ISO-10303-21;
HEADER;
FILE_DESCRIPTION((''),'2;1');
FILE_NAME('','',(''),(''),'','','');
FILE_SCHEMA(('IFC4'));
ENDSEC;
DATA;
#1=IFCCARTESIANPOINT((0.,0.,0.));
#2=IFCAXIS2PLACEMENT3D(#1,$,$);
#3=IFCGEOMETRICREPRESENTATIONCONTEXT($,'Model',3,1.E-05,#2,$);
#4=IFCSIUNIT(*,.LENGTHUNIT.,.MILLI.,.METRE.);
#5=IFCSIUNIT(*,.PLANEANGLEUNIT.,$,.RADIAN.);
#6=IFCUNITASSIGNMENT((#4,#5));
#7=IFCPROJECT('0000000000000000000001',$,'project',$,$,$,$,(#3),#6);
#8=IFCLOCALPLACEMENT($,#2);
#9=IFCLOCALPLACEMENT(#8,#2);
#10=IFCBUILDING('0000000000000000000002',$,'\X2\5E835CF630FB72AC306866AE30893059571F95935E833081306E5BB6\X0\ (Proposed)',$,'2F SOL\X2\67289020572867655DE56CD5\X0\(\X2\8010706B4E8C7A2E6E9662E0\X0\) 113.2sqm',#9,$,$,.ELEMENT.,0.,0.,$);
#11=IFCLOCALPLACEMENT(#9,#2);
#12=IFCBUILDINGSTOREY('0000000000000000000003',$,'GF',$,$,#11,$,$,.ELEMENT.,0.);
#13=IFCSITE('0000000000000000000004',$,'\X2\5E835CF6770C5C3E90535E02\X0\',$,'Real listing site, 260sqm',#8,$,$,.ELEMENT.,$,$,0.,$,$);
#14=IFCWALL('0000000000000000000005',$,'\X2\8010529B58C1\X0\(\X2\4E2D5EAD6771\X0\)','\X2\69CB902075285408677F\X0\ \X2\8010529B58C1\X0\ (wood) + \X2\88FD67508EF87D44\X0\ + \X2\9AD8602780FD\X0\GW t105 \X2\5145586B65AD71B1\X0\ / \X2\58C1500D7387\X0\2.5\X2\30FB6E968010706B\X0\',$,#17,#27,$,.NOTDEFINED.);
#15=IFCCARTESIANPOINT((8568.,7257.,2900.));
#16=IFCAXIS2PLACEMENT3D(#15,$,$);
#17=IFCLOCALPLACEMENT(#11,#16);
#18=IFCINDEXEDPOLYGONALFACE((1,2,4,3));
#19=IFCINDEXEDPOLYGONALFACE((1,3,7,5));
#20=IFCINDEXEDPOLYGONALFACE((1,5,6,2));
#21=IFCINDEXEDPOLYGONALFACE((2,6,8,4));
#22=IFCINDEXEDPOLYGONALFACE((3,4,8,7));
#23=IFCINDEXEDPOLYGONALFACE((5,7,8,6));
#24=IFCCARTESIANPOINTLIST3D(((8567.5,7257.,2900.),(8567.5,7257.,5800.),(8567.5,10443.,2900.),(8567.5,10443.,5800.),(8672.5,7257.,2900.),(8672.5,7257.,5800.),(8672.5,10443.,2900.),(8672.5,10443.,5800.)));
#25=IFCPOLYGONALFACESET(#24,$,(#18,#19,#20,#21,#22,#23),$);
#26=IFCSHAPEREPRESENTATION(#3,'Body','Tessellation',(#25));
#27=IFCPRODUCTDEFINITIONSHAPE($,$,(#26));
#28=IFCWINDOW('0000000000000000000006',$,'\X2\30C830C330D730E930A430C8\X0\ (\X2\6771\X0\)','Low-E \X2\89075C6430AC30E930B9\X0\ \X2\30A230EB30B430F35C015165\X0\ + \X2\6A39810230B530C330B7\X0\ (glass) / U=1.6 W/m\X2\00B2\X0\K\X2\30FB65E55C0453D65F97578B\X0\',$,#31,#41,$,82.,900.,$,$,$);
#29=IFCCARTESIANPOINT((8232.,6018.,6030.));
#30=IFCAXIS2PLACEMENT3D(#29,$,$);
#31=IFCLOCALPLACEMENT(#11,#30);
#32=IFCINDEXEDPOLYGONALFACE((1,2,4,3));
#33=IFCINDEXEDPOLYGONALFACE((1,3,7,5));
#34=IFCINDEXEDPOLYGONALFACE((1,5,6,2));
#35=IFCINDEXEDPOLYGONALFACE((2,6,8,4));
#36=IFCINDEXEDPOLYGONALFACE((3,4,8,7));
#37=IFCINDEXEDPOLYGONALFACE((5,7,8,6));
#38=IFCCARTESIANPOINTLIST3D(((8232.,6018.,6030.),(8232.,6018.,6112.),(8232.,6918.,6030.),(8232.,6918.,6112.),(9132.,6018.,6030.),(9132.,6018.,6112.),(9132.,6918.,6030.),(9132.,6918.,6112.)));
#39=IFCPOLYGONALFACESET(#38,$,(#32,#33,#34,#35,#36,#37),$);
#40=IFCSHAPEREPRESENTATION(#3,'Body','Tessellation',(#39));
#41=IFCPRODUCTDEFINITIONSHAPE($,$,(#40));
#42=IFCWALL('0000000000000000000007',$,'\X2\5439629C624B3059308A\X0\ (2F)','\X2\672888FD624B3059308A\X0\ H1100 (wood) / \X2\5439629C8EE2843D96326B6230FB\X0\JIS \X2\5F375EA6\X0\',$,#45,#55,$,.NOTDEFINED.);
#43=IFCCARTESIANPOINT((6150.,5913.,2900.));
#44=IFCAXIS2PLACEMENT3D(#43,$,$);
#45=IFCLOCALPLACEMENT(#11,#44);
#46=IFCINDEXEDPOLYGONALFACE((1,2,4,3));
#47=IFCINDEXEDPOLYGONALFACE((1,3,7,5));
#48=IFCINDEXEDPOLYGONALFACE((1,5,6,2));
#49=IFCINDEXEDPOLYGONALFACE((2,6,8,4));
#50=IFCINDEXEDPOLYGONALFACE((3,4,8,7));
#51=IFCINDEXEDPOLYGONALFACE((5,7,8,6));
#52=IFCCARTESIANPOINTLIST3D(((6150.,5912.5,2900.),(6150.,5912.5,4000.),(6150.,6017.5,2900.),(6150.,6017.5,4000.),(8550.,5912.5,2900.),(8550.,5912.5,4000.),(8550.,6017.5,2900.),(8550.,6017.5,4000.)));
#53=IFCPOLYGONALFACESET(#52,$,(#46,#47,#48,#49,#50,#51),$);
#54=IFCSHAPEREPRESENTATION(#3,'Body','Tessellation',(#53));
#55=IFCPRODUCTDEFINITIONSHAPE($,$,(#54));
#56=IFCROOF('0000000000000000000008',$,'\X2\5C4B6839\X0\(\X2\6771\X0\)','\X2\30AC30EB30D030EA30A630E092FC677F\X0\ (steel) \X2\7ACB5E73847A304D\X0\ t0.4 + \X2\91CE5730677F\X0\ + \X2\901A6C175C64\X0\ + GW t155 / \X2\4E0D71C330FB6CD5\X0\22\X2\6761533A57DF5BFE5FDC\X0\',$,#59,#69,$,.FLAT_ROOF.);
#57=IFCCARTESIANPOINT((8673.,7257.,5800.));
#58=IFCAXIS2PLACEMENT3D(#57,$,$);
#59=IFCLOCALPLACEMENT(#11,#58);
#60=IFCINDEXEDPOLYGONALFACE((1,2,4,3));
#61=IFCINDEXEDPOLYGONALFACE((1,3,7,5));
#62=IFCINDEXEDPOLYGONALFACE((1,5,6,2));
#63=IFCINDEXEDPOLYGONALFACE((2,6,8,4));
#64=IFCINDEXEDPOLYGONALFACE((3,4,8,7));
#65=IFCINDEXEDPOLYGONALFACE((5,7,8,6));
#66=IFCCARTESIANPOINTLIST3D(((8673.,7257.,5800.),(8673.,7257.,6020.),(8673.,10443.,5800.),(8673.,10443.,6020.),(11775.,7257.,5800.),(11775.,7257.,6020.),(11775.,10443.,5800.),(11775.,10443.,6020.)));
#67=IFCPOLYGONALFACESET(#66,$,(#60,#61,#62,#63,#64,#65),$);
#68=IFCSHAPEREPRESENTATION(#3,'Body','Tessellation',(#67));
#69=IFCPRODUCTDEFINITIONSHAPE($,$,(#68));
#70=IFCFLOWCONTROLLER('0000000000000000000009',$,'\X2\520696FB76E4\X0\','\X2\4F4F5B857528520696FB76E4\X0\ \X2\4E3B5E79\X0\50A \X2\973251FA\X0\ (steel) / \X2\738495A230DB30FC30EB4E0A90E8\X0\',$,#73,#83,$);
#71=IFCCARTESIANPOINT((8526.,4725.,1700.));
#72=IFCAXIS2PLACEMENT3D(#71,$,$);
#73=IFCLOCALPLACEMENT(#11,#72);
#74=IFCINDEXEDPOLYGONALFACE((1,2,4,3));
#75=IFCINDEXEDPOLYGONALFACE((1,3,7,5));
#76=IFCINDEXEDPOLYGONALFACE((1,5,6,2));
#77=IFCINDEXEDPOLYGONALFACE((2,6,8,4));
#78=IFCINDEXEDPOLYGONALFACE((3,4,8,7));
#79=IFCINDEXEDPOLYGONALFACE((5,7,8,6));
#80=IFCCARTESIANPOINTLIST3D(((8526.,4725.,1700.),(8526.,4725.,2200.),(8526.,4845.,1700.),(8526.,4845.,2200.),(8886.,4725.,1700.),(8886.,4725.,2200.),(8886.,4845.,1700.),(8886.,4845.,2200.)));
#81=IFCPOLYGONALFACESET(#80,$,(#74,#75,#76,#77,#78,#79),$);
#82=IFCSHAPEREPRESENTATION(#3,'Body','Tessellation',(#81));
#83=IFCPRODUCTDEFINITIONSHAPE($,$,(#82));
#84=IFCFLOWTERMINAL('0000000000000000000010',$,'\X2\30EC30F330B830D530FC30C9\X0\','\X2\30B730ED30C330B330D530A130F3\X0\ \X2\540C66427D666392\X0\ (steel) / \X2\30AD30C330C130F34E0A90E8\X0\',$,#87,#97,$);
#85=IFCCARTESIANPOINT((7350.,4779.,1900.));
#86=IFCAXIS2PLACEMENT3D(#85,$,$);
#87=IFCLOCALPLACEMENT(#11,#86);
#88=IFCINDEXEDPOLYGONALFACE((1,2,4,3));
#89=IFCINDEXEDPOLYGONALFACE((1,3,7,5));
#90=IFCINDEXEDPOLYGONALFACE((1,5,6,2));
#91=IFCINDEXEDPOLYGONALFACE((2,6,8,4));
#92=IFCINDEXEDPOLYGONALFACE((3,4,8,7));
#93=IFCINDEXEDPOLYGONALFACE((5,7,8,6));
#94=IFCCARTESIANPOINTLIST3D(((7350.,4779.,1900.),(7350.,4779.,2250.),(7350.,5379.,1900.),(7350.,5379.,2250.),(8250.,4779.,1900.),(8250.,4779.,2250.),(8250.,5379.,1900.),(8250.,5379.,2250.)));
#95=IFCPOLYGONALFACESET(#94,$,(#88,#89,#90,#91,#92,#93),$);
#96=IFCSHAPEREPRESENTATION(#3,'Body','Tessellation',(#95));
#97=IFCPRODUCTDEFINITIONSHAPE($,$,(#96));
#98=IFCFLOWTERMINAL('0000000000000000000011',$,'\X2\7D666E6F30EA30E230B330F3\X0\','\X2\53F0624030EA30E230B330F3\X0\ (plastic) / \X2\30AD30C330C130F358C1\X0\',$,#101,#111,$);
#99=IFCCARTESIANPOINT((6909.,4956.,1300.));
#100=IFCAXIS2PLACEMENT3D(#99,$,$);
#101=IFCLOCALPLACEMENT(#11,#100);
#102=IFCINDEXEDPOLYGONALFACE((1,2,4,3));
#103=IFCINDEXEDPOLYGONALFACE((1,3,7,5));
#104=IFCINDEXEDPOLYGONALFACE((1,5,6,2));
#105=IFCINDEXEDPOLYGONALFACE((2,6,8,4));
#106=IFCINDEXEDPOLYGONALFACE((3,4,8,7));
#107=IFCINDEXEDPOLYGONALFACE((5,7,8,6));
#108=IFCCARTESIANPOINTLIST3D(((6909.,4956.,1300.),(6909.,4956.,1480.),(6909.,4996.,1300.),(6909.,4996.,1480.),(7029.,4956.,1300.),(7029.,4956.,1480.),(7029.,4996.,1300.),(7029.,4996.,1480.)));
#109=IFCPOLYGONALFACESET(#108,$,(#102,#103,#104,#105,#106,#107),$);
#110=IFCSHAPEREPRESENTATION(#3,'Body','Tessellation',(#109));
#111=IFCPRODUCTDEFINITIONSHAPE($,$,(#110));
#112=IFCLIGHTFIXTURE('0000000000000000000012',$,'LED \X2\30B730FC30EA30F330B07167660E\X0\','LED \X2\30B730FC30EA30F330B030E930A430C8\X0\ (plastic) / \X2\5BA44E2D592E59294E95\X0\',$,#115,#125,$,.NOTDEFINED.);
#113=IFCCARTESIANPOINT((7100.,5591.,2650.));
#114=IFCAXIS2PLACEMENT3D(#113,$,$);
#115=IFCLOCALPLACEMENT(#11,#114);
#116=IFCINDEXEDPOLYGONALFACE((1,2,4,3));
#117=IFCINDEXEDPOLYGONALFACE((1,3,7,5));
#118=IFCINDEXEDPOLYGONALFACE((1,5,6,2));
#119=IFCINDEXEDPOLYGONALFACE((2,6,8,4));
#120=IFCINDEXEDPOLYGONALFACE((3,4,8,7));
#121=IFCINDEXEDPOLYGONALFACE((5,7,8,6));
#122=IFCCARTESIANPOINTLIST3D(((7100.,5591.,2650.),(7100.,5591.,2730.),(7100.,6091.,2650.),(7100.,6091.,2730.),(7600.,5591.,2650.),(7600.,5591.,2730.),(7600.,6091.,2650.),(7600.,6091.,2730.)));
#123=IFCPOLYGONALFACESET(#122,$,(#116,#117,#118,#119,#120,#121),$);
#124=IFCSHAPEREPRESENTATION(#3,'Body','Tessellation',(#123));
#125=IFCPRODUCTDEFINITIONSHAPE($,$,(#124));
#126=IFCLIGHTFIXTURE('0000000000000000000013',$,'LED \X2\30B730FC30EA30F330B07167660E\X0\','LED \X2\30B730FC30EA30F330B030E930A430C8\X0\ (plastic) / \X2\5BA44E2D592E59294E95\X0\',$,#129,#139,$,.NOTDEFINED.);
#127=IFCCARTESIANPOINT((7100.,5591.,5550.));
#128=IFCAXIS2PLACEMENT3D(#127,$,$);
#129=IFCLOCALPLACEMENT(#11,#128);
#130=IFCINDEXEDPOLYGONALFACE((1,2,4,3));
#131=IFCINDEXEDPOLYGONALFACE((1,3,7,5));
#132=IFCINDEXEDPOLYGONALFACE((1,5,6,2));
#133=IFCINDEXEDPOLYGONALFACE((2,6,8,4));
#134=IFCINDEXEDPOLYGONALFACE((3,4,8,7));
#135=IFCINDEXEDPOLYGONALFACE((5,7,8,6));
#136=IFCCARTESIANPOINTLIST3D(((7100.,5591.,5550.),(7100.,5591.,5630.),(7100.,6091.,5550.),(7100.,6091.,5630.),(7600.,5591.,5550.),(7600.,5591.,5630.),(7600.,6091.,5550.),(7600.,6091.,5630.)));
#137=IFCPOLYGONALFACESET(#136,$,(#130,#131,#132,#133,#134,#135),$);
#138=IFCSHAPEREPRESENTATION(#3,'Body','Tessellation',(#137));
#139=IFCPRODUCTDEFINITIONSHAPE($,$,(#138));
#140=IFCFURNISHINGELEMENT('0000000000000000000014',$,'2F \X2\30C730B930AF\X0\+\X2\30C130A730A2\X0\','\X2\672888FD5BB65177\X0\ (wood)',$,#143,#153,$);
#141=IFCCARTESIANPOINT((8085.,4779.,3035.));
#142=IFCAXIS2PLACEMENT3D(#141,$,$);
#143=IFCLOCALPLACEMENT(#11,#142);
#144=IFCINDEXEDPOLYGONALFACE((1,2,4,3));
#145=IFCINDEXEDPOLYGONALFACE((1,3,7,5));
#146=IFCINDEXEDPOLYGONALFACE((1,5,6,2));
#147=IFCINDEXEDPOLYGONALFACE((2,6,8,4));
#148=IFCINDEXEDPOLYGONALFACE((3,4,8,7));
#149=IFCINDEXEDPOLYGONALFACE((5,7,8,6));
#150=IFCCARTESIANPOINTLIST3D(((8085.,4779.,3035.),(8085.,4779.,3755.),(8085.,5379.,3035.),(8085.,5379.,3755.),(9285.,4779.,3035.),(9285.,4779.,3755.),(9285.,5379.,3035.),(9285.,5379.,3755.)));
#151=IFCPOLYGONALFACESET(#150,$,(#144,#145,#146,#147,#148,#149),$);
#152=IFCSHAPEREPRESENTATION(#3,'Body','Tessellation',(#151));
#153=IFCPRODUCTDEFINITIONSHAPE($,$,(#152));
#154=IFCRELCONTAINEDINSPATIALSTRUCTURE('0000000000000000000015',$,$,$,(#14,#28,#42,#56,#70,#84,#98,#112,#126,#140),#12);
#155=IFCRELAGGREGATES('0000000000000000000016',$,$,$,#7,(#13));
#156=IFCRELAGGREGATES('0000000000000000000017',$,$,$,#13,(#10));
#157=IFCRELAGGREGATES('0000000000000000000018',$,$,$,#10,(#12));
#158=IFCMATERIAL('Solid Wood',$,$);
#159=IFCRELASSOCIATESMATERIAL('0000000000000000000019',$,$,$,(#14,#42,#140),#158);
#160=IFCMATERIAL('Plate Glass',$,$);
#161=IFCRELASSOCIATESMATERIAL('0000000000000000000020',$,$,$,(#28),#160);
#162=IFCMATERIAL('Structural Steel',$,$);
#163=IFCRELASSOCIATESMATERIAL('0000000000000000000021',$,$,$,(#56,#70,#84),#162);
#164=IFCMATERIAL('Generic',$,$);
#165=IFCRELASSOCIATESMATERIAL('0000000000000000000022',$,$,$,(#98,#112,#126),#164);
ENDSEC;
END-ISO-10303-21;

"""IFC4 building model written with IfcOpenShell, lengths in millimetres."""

from ifc_helpers import new_model, si_unit, frame, frame_2d, origin, place, context, project, spatial, rectangle, extrude, material, element, save


model = new_model("IFC4")

# Units and contexts
model_context = context("Model", 3, precision=1e-05, world=origin())
ifc_project = project(units=[si_unit("LENGTHUNIT", "METRE", prefix="MILLI"), si_unit("PLANEANGLEUNIT", "RADIAN")], contexts=[model_context])

# Site, building, storey
site_placement = place(None, origin())
site = spatial("IfcSite", under=ifc_project, at=site_placement, Name="広島県尾道市", ObjectType="Real listing site, 260sqm", CompositionType="ELEMENT", RefElevation=0.0)
building_placement = place(site_placement, origin())
building = spatial("IfcBuilding", under=site, at=building_placement, Name="広島・犬と暮らす土間広めの家 (Proposed)", ObjectType="2F SOL木造在来工法(耐火二種準拠) 113.2sqm", CompositionType="ELEMENT", ElevationOfRefHeight=0.0, ElevationOfTerrain=0.0)
storey_placement = place(building_placement, origin())
storey = spatial("IfcBuildingStorey", under=building, at=storey_placement, Name="GF", CompositionType="ELEMENT", Elevation=0.0)

# Shared definitions
ifc_material_1 = material(Name="Solid Wood")

# Shared definitions
ifc_material_2 = material(Name="Plate Glass")

# Wall
wall_1_placement = place(storey_placement, frame((8568.0, 7257.0, 2900.0)))
element("IfcWall", 1, at=wall_1_placement, inside=storey, material=ifc_material_1, Name="耐力壁(中庭東)", Description="構造用合板 耐力壁 (wood) + 製材軸組 + 高性能GW t105 充填断熱 / 壁倍率2.5・準耐火", PredefinedType="NOTDEFINED", context=model_context, shape_type="SweptSolid", body=[
    extrude(rectangle(XDim=105.0, YDim=3186.0, at=frame_2d((52.0, 1593.0))), frame((8568.0, 7257.0, 2900.0)), (0.0, 0.0, 1.0), 2900.0),
])

# Window
window_1_placement = place(storey_placement, frame((8232.0, 6018.0, 6030.0)))
element("IfcWindow", 2, at=window_1_placement, inside=storey, material=ifc_material_2, Name="トップライト (東)", Description="Low-E 複層ガラス アルゴン封入 + 樹脂サッシ (glass) / U=1.6 W/m²K・日射取得型", OverallHeight=82.0, OverallWidth=900.0, context=model_context, shape_type="SweptSolid", body=[
    extrude(rectangle(XDim=900.0, YDim=900.0, at=frame_2d((450.0, 450.0))), frame((8232.0, 6018.0, 6030.0)), (0.0, 0.0, 1.0), 82.0),
])

# Wall
wall_2_placement = place(storey_placement, frame((6150.0, 5913.0, 2900.0)))
element("IfcWall", 3, at=wall_2_placement, inside=storey, material=ifc_material_1, Name="吹抜手すり (2F)", Description="木製手すり H1100 (wood) / 吹抜転落防止・JIS 強度", PredefinedType="NOTDEFINED", context=model_context, shape_type="SweptSolid", body=[
    extrude(rectangle(XDim=2400.0, YDim=105.0, at=frame_2d((1200.0, 52.0))), frame((6150.0, 5913.0, 2900.0)), (0.0, 0.0, 1.0), 1100.0),
])

# Roof
ifc_material_3 = material(Name="Structural Steel")
for number, where, name in (
    (4, (8673.0, 7257.0, 5800.0), "屋根(東)"),
):
    element("IfcRoof", number, at=place(storey_placement, frame(where)), inside=storey, material=ifc_material_3, Name=name, Description="ガルバリウム鋼板 (steel) 立平葺き t0.4 + 野地板 + 通気層 + GW t155 / 不燃・法22条区域対応", PredefinedType="FLAT_ROOF", context=model_context, shape_type="SweptSolid", body=[
        extrude(rectangle(XDim=3102.0, YDim=3186.0, at=frame_2d((1551.0, 1593.0))), frame((8673.0, 7257.0, 5800.0)), (0.0, 0.0, 1.0), 220.0),
    ])

# Flow controller
flow_controller_placement = place(storey_placement, frame((8526.0, 4725.0, 1700.0)))
element("IfcFlowController", 5, at=flow_controller_placement, inside=storey, material=ifc_material_3, Name="分電盤", Description="住宅用分電盤 主幹50A 露出 (steel) / 玄関ホール上部", context=model_context, shape_type="SweptSolid", body=[
    extrude(rectangle(XDim=360.0, YDim=120.0, at=frame_2d((180.0, 60.0))), frame((8526.0, 4725.0, 1700.0)), (0.0, 0.0, 1.0), 500.0),
])

# Flow terminals
flow_terminal_1_placement = place(storey_placement, frame((7350.0, 4779.0, 1900.0)))
element("IfcFlowTerminal", 6, at=flow_terminal_1_placement, inside=storey, material=ifc_material_3, Name="レンジフード", Description="シロッコファン 同時給排 (steel) / キッチン上部", context=model_context, shape_type="SweptSolid", body=[
    extrude(rectangle(XDim=900.0, YDim=600.0, at=frame_2d((450.0, 300.0))), frame((7350.0, 4779.0, 1900.0)), (0.0, 0.0, 1.0), 350.0),
])
ifc_material_4 = material(Name="Generic")
flow_terminal_2_placement = place(storey_placement, frame((6909.0, 4956.0, 1300.0)))
element("IfcFlowTerminal", 7, at=flow_terminal_2_placement, inside=storey, material=ifc_material_4, Name="給湯リモコン", Description="台所リモコン (plastic) / キッチン壁", context=model_context, shape_type="SweptSolid", body=[
    extrude(rectangle(XDim=120.0, YDim=40.0, at=frame_2d((60.0, 20.0))), frame((6909.0, 4956.0, 1300.0)), (0.0, 0.0, 1.0), 180.0),
])

# Light fixtures
light_fixture_1_placement = place(storey_placement, frame((7100.0, 5591.0, 2650.0)))
element("IfcLightFixture", 8, at=light_fixture_1_placement, inside=storey, material=ifc_material_4, Name="LED シーリング照明", Description="LED シーリングライト (plastic) / 室中央天井", PredefinedType="NOTDEFINED", context=model_context, shape_type="SweptSolid", body=[
    extrude(rectangle(XDim=500.0, YDim=500.0, at=frame_2d((250.0, 250.0))), frame((7100.0, 5591.0, 2650.0)), (0.0, 0.0, 1.0), 80.0),
])
light_fixture_2_placement = place(storey_placement, frame((7100.0, 5591.0, 5550.0)))
element("IfcLightFixture", 9, at=light_fixture_2_placement, inside=storey, material=ifc_material_4, Name="LED シーリング照明", Description="LED シーリングライト (plastic) / 室中央天井", PredefinedType="NOTDEFINED", context=model_context, shape_type="SweptSolid", body=[
    extrude(rectangle(XDim=500.0, YDim=500.0, at=frame_2d((250.0, 250.0))), frame((7100.0, 5591.0, 5550.0)), (0.0, 0.0, 1.0), 80.0),
])

# Furnishing element
furnishing_placement = place(storey_placement, frame((8085.0, 4779.0, 3035.0)))
element("IfcFurnishingElement", 10, at=furnishing_placement, inside=storey, material=ifc_material_1, Name="2F デスク+チェア", Description="木製家具 (wood)", context=model_context, shape_type="SweptSolid", body=[
    extrude(rectangle(XDim=1200.0, YDim=600.0, at=frame_2d((600.0, 300.0))), frame((8085.0, 4779.0, 3035.0)), (0.0, 0.0, 1.0), 720.0),
])

save(model, "model.ifc")
